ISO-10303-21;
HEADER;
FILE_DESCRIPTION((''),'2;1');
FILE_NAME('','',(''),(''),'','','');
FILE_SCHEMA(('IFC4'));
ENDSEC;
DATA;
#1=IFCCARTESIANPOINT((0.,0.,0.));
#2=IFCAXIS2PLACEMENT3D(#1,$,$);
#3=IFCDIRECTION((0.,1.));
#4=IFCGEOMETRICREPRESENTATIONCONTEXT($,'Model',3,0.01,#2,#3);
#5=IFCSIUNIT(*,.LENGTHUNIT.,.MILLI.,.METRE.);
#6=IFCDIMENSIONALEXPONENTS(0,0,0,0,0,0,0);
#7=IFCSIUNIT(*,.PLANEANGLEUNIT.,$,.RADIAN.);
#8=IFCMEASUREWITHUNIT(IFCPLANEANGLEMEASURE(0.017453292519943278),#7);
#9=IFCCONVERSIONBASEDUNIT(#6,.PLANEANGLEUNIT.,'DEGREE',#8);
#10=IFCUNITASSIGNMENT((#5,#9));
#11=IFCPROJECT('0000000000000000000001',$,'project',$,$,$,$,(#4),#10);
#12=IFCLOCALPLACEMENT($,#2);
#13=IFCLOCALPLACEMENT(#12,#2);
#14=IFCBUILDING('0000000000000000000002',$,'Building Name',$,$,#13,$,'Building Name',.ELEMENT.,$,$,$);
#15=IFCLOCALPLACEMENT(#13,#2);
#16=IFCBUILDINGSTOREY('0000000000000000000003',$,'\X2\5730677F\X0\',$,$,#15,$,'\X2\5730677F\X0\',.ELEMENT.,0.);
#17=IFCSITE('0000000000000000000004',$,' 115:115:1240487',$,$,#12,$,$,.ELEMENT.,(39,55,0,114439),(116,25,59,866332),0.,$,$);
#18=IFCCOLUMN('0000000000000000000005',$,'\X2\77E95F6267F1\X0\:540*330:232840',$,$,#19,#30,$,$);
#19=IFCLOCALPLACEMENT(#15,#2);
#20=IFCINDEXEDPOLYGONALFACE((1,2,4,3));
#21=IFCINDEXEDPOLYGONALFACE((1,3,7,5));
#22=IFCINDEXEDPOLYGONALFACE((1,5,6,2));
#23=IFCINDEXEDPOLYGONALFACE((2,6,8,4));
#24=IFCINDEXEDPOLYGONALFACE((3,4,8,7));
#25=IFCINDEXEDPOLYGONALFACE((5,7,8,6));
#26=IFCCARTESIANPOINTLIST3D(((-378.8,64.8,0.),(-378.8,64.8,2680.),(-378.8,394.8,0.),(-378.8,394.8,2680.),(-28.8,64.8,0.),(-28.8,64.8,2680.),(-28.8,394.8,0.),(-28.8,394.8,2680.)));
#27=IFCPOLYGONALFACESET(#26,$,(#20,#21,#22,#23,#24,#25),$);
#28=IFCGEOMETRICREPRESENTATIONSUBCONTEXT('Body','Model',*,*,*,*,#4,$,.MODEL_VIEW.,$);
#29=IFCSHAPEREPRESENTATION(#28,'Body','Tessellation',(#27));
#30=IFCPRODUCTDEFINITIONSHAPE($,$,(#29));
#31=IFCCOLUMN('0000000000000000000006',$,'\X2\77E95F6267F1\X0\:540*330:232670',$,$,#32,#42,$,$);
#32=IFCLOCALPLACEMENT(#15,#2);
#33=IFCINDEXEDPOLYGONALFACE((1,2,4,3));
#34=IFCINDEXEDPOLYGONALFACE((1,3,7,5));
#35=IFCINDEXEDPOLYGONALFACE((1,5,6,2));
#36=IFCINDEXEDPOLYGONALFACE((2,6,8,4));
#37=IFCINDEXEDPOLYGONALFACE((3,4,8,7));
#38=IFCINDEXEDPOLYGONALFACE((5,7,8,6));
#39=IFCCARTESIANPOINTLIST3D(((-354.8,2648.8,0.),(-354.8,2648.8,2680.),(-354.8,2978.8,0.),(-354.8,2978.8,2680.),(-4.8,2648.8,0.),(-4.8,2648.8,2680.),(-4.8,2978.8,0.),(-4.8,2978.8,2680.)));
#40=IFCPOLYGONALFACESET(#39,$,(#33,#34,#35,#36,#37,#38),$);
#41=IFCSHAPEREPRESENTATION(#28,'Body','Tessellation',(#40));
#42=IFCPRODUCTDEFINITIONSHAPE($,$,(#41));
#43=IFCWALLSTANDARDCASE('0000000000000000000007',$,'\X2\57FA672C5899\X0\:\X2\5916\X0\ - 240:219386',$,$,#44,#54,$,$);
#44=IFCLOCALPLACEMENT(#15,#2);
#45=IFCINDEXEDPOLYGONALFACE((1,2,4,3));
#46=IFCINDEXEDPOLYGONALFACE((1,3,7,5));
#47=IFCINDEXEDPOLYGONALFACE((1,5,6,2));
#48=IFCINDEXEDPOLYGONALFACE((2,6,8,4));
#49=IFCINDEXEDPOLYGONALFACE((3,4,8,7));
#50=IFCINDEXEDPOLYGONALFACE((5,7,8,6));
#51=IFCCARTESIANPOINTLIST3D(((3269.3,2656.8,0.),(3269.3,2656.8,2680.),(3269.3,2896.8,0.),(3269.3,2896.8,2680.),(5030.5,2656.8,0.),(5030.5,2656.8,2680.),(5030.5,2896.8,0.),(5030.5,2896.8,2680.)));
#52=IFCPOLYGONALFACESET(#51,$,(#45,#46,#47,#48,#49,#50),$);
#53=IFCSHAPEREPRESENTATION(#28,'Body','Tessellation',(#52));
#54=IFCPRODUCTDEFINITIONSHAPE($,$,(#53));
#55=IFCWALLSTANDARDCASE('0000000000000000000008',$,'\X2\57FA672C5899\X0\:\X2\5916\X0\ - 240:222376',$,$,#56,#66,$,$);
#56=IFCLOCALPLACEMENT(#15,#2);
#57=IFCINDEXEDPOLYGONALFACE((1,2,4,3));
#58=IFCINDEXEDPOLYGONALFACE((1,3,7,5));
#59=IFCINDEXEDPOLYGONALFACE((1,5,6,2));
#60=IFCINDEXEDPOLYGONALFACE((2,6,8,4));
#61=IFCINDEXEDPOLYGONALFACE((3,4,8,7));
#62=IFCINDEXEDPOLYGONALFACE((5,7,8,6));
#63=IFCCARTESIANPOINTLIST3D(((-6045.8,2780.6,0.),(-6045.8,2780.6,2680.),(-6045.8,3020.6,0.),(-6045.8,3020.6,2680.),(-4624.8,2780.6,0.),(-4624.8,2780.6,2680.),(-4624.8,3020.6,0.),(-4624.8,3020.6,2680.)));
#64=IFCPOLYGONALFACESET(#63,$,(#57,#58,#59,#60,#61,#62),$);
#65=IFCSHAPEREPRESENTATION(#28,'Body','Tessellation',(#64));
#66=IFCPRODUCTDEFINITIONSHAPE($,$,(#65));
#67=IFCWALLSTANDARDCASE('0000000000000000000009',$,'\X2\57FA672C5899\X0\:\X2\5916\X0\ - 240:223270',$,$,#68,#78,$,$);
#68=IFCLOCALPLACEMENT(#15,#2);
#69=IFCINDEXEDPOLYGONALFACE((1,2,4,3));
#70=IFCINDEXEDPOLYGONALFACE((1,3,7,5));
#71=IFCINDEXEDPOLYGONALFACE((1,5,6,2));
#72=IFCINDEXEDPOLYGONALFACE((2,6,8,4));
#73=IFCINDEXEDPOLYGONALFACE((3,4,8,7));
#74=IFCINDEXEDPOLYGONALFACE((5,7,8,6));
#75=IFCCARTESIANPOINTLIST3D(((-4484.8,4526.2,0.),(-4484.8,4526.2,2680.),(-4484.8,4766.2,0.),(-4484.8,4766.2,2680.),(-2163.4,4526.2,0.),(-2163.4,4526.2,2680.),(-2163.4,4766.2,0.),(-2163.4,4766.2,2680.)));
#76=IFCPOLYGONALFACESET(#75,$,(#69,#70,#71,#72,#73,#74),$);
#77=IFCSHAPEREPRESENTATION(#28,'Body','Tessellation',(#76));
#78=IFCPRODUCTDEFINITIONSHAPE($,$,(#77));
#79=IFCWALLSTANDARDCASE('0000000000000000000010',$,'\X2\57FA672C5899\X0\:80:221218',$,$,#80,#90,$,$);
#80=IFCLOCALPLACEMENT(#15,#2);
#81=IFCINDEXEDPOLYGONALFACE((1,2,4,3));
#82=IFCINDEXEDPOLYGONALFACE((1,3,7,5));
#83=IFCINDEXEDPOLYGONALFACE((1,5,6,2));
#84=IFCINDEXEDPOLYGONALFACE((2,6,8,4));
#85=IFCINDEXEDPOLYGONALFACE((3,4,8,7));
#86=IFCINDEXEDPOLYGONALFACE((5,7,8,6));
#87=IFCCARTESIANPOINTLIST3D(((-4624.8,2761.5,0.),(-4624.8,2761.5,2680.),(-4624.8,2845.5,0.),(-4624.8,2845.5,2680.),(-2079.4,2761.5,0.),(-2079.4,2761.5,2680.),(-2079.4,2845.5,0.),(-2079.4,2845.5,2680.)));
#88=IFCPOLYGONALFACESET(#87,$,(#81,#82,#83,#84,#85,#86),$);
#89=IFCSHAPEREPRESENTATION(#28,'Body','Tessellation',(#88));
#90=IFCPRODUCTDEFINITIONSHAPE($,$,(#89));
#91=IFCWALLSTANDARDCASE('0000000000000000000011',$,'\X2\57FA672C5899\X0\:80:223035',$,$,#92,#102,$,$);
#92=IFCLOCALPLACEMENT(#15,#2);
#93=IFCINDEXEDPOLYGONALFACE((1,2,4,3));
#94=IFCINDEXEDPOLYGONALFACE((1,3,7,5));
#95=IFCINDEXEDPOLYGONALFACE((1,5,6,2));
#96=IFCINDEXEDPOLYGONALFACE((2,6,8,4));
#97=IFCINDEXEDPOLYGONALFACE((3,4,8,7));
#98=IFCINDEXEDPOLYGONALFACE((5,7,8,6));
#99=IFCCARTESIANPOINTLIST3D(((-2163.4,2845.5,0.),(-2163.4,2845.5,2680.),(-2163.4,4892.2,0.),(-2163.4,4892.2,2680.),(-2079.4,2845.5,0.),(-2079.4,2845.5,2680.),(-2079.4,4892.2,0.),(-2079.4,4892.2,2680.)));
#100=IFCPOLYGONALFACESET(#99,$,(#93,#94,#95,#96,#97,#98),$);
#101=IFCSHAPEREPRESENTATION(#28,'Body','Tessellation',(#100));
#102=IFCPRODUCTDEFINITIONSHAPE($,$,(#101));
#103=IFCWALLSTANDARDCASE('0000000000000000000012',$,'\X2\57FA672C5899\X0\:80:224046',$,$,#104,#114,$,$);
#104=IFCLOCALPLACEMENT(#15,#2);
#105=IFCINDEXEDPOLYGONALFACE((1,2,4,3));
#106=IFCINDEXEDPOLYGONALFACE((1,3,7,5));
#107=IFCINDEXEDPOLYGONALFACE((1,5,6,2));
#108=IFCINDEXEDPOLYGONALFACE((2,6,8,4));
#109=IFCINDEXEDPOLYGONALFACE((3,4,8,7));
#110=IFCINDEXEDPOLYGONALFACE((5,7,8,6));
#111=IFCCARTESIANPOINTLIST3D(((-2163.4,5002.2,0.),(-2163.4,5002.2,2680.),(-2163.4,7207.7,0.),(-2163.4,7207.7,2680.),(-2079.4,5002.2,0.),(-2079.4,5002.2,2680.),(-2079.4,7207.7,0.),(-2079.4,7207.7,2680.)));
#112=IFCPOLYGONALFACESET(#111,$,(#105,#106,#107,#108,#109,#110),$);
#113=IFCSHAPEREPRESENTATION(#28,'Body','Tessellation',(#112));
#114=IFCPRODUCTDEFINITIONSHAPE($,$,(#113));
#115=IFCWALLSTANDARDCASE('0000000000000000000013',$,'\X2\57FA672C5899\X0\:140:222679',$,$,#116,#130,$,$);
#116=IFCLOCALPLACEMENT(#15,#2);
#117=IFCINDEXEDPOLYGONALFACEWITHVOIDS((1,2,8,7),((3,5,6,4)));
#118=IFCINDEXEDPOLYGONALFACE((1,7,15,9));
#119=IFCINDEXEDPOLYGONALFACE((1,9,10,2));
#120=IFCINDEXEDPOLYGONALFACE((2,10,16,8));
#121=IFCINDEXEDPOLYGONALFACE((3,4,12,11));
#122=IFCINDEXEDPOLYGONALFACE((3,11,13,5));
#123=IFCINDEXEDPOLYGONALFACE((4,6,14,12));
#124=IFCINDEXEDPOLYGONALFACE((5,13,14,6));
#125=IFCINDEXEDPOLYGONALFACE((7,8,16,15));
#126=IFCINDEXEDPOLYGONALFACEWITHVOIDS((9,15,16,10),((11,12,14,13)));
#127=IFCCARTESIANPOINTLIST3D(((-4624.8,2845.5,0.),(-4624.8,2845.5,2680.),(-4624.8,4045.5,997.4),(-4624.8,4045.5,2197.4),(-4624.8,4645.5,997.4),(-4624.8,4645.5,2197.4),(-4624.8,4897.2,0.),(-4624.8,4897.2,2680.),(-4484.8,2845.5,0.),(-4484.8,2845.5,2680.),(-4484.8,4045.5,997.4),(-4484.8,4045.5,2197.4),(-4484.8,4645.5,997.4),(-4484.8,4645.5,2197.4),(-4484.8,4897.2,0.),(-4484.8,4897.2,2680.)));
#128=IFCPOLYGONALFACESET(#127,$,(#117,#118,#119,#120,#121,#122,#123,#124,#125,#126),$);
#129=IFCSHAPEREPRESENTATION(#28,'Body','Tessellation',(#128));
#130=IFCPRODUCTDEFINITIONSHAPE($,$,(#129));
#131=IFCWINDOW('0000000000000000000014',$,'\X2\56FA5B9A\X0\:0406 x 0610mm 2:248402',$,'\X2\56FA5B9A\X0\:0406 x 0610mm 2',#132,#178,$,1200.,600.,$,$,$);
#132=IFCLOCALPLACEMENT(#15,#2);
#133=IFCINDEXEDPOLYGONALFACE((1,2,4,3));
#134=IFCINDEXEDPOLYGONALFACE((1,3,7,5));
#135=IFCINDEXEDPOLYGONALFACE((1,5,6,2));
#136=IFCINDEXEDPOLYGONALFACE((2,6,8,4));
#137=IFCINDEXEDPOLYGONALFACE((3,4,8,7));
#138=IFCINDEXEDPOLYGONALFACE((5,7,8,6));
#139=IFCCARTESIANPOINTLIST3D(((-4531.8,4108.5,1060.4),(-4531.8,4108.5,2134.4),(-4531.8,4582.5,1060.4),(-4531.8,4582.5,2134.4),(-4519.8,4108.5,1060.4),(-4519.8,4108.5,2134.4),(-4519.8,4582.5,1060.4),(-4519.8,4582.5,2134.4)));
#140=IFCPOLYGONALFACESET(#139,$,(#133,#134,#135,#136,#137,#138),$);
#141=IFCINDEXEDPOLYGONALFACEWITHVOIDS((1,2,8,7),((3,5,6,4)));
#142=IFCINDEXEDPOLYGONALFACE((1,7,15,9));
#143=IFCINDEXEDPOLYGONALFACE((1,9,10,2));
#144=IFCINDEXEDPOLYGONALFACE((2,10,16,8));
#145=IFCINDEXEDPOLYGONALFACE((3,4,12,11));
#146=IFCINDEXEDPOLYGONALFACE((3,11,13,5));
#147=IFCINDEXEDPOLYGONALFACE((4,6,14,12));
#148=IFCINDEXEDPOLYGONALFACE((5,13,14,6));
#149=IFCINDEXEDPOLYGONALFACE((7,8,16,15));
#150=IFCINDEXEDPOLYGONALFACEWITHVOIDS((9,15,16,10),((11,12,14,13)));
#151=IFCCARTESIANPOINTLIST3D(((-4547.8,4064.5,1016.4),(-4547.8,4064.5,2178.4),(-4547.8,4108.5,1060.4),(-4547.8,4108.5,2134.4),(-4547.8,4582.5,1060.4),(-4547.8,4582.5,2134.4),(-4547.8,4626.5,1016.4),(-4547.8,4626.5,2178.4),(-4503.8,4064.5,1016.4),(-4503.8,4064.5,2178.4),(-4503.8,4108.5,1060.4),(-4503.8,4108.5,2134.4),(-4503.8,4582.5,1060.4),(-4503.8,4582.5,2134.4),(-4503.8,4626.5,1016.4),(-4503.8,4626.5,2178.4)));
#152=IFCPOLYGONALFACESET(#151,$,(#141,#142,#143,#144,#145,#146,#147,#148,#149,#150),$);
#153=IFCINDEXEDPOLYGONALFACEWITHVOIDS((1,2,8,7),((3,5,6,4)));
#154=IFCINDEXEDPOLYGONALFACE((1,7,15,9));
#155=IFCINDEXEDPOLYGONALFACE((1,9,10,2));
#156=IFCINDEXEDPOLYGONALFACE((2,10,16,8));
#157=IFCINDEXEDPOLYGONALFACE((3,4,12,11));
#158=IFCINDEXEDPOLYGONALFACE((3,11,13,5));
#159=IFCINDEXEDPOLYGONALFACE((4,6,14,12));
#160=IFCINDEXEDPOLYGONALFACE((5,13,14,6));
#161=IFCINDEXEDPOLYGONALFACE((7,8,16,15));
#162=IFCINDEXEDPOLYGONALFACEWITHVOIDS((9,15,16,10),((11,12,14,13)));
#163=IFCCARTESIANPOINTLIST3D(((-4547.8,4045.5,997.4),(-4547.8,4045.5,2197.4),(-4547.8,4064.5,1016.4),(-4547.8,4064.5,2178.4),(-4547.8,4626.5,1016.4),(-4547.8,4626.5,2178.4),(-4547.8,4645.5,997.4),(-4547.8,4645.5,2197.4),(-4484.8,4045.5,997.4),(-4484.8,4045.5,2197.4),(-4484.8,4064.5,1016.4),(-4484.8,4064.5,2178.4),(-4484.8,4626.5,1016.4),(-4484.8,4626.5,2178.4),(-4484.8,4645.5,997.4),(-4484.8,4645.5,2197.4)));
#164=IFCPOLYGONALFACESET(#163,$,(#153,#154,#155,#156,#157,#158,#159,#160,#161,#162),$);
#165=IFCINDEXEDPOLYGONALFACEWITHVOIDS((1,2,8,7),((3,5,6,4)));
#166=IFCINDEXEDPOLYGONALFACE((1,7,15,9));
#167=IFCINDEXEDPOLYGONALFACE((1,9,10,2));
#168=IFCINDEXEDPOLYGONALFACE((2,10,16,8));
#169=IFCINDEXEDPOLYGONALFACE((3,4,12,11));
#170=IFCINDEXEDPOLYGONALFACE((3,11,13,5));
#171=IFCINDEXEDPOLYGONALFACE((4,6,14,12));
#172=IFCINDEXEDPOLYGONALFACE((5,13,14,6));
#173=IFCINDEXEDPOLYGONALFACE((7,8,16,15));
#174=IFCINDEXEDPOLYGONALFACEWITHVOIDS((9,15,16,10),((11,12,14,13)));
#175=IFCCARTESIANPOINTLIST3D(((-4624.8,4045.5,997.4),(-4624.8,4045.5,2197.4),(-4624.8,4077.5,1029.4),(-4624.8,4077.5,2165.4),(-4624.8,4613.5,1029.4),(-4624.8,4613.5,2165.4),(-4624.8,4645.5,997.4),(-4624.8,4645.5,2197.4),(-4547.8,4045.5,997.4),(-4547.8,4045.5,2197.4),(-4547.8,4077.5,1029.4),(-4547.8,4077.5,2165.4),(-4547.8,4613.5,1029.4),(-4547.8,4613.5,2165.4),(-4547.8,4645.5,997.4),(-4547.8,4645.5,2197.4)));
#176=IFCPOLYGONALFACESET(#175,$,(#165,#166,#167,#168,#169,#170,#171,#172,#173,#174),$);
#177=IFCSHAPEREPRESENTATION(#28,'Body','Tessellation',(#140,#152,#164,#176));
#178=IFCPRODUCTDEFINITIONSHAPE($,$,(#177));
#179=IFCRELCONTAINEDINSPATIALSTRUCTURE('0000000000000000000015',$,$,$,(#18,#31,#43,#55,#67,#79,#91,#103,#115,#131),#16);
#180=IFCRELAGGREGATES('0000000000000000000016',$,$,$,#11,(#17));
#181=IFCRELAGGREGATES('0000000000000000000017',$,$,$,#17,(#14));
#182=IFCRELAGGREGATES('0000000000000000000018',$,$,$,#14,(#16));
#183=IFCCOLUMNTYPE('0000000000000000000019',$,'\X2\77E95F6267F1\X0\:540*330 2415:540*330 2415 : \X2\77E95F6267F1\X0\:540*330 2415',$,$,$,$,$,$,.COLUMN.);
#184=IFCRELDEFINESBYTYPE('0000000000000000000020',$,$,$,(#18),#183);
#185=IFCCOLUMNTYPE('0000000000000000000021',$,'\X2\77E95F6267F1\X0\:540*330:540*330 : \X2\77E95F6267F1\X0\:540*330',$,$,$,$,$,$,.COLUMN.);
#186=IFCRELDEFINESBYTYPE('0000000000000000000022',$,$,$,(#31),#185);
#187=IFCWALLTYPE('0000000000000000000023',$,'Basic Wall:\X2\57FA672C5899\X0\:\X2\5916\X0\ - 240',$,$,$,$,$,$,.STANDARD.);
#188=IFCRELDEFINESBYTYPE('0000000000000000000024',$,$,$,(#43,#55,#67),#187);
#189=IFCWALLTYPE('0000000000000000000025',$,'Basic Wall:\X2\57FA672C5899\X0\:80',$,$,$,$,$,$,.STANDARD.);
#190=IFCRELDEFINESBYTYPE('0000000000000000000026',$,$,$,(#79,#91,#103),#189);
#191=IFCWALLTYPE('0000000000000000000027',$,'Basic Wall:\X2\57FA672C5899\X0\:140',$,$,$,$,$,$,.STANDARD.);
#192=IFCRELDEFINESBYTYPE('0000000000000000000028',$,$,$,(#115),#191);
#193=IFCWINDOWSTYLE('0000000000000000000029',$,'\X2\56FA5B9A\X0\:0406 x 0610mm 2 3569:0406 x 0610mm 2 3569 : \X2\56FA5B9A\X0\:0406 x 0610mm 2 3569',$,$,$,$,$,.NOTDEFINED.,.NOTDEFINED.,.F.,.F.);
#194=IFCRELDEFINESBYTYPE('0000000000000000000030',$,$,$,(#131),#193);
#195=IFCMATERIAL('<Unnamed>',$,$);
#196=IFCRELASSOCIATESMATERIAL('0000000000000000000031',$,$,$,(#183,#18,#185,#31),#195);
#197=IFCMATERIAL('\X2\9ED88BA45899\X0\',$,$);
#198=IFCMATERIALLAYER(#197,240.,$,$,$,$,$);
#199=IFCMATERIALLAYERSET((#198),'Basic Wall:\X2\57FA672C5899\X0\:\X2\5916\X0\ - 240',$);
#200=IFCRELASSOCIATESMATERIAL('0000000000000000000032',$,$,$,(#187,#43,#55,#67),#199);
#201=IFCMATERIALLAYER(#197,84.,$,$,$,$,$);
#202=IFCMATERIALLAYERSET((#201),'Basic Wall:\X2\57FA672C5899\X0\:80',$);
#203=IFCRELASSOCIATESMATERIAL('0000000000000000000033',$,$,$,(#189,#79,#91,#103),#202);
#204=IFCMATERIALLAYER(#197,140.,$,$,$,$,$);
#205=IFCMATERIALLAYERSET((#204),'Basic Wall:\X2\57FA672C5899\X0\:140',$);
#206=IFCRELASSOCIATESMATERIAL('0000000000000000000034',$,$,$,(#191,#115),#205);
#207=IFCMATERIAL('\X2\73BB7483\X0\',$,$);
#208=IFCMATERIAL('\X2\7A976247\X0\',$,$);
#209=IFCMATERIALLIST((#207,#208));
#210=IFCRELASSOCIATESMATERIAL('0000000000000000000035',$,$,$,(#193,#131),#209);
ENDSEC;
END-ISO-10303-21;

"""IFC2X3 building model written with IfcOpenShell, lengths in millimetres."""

from ifc_helpers import new_model, entity, si_unit, converted_unit, direction, frame, frame_2d, origin, origin_2d_with_axis, place, context, subcontext, project, spatial, polyline, rectangle, outline, extrude, source, transform, mapped, material, material_list, layer, layer_set, layer_usage, type_object, type_shapes, element, fill, save


model = new_model("IFC2X3")

# Units and contexts
model_context = context("Model", 3, precision=0.01, world=origin(), true_north=direction((0.0, 1.0)))
body_context = subcontext(model_context, "Body", "Model", "MODEL_VIEW")
ifc_project = project(units=[si_unit("LENGTHUNIT", "METRE", prefix="MILLI"), converted_unit("PLANEANGLEUNIT", "DEGREE", entity("IfcPlaneAngleMeasure", 0.017453292519943278), si_unit("PLANEANGLEUNIT", "RADIAN"), dimensions=[0, 0, 0, 0, 0, 0, 0])], contexts=[model_context])

# Site, building, storey
site_placement = place(None, origin())
site = spatial("IfcSite", under=ifc_project, at=site_placement, Name=" 115:115:1240487", CompositionType="ELEMENT", RefLatitude=(39, 55, 0, 114439), RefLongitude=(116, 25, 59, 866332), RefElevation=0.0)
building_placement = place(site_placement, origin())
building = spatial("IfcBuilding", under=site, at=building_placement, Name="Building Name", LongName="Building Name", CompositionType="ELEMENT")
storey_placement = place(building_placement, origin())
storey = spatial("IfcBuildingStorey", under=building, at=storey_placement, Name="地板", LongName="地板", CompositionType="ELEMENT", Elevation=0.0)

# Columns
ifc_material_1 = material(Name="<Unnamed>")
column_type_1 = type_object("IfcColumnType", Name="矩形柱:540*330 2415:540*330 2415 : 矩形柱:540*330 2415", PredefinedType="COLUMN", material=ifc_material_1)
shared_shape_1 = source(origin(), body_context, "Body", "SweptSolid", [
    extrude(rectangle(XDim=350.0, YDim=330.0, at=origin_2d_with_axis()), frame((-203.8, 229.8, 0.0)), (0.0, 0.0, 1.0), 2680.0),
])
type_shapes(column_type_1, [shared_shape_1])
column_1_placement = place(storey_placement, origin())
element("IfcColumn", 1, at=column_1_placement, inside=storey, type_object=column_type_1, material=ifc_material_1, Name="矩形柱:540*330:232840", context=body_context, shape_type="MappedRepresentation", body=[
    mapped(shared_shape_1, transform((0.0, 0.0, 0.0), scale=1.0)),
])
column_type_2 = type_object("IfcColumnType", Name="矩形柱:540*330:540*330 : 矩形柱:540*330", PredefinedType="COLUMN", material=ifc_material_1)
shared_shape_2 = source(origin(), body_context, "Body", "SweptSolid", [
    extrude(rectangle(XDim=350.0, YDim=330.0, at=frame_2d((0.0, 0.0), x_axis=(1.0, 0.0))), frame((-179.8, 2813.8, 0.0)), (0.0, 0.0, 1.0), 2680.0),
])
type_shapes(column_type_2, [shared_shape_2])
column_2_placement = place(storey_placement, origin())
element("IfcColumn", 2, at=column_2_placement, inside=storey, type_object=column_type_2, material=ifc_material_1, Name="矩形柱:540*330:232670", context=body_context, shape_type="MappedRepresentation", body=[
    mapped(shared_shape_2, transform((0.0, 0.0, 0.0), scale=1.0)),
])
ifc_material_2 = material(Name="默认墙")

# Walls
ifc_layer_1 = layer(ifc_material_2, 240.0)
ifc_layer_set_1 = layer_set([ifc_layer_1], Name="Basic Wall:基本墙:外 - 240")
ifc_layer_usage_1 = layer_usage(ifc_layer_set_1, "AXIS2", "NEGATIVE", 120.0)
wall_type_1 = type_object("IfcWallType", Name="Basic Wall:基本墙:外 - 240", PredefinedType="STANDARD", material=ifc_layer_set_1)
wall_1_placement = place(storey_placement, frame((5030.5, 2776.8, 0.0), z_axis=(0.0, 0.0, 1.0), x_axis=(-1.0, 0.0, 0.0)))
element("IfcWallStandardCase", 3, at=wall_1_placement, inside=storey, type_object=wall_type_1, material=ifc_layer_usage_1, Name="基本墙:外 - 240:219386", context=body_context, shape_type="SweptSolid", body=[
    extrude(rectangle(XDim=1761.2, YDim=240.0, at=frame_2d((880.6, 0.0), x_axis=(-1.0, 0.0))), origin(), (0.0, 0.0, 1.0), 2680.0),
])
ifc_layer_usage_2 = layer_usage(ifc_layer_set_1, "AXIS2", "NEGATIVE", 120.0)
wall_2_placement = place(storey_placement, frame((-6045.8, 2900.6, 0.0)))
element("IfcWallStandardCase", 4, at=wall_2_placement, inside=storey, type_object=wall_type_1, material=ifc_layer_usage_2, Name="基本墙:外 - 240:222376", context=body_context, shape_type="SweptSolid", body=[
    extrude(rectangle(XDim=1421.1, YDim=240.0, at=frame_2d((710.5, 0.0), x_axis=(-1.0, 0.0))), origin(), (0.0, 0.0, 1.0), 2680.0),
])
ifc_layer_usage_3 = layer_usage(ifc_layer_set_1, "AXIS2", "NEGATIVE", 120.0)
wall_3_placement = place(storey_placement, frame((-4484.8, 4646.2, 0.0)))
element("IfcWallStandardCase", 5, at=wall_3_placement, inside=storey, type_object=wall_type_1, material=ifc_layer_usage_3, Name="基本墙:外 - 240:223270", context=body_context, shape_type="SweptSolid", body=[
    extrude(rectangle(XDim=2321.3, YDim=240.0, at=frame_2d((1160.7, 0.0), x_axis=(-1.0, 0.0))), origin(), (0.0, 0.0, 1.0), 2680.0),
])
ifc_layer_2 = layer(ifc_material_2, 84.0)
ifc_layer_set_2 = layer_set([ifc_layer_2], Name="Basic Wall:基本墙:80")
ifc_layer_usage_4 = layer_usage(ifc_layer_set_2, "AXIS2", "NEGATIVE", 42.0)
wall_type_2 = type_object("IfcWallType", Name="Basic Wall:基本墙:80", PredefinedType="STANDARD", material=ifc_layer_set_2)
wall_4_placement = place(storey_placement, frame((-4624.8, 2803.5, 0.0)))
element("IfcWallStandardCase", 6, at=wall_4_placement, inside=storey, type_object=wall_type_2, material=ifc_layer_usage_4, Name="基本墙:80:221218", context=body_context, shape_type="SweptSolid", body=[
    extrude(rectangle(XDim=2545.3, YDim=84.0, at=frame_2d((1272.7, 0.0), x_axis=(-1.0, 0.0))), origin(), (0.0, 0.0, 1.0), 2680.0),
])
ifc_layer_usage_5 = layer_usage(ifc_layer_set_2, "AXIS2", "NEGATIVE", 42.0)
wall_5_placement = place(storey_placement, frame((-2121.4, 2845.5, 0.0), z_axis=(0.0, 0.0, 1.0), x_axis=(0.0, 1.0, 0.0)))
element("IfcWallStandardCase", 7, at=wall_5_placement, inside=storey, type_object=wall_type_2, material=ifc_layer_usage_5, Name="基本墙:80:223035", context=body_context, shape_type="SweptSolid", body=[
    extrude(rectangle(XDim=2046.6, YDim=84.0, at=frame_2d((1023.3, 0.0), x_axis=(-1.0, 0.0))), origin(), (0.0, 0.0, 1.0), 2680.0),
])
ifc_layer_usage_6 = layer_usage(ifc_layer_set_2, "AXIS2", "NEGATIVE", 42.0)
wall_6_placement = place(storey_placement, frame((-2121.4, 5002.2, 0.0), z_axis=(0.0, 0.0, 1.0), x_axis=(0.0, 1.0, 0.0)))
element("IfcWallStandardCase", 8, at=wall_6_placement, inside=storey, type_object=wall_type_2, material=ifc_layer_usage_6, Name="基本墙:80:224046", context=body_context, shape_type="SweptSolid", body=[
    extrude(rectangle(XDim=2205.5, YDim=84.0, at=frame_2d((1102.8, 0.0), x_axis=(-1.0, 0.0))), origin(), (0.0, 0.0, 1.0), 2680.0),
])

# Wall, opening, window
ifc_layer_3 = layer(ifc_material_2, 140.0)
ifc_layer_set_3 = layer_set([ifc_layer_3], Name="Basic Wall:基本墙:140")
ifc_layer_usage_7 = layer_usage(ifc_layer_set_3, "AXIS2", "NEGATIVE", 70.0)
wall_type_3 = type_object("IfcWallType", Name="Basic Wall:基本墙:140", PredefinedType="STANDARD", material=ifc_layer_set_3)
wall_7_placement = place(storey_placement, frame((-4554.8, 2845.5, 0.0), z_axis=(0.0, 0.0, 1.0), x_axis=(0.0, 1.0, 0.0)))
wall_7 = element("IfcWallStandardCase", 9, at=wall_7_placement, inside=storey, type_object=wall_type_3, material=ifc_layer_usage_7, Name="基本墙:140:222679", context=body_context, shape_type="SweptSolid", body=[
    extrude(rectangle(XDim=2051.7, YDim=140.0, at=frame_2d((1025.8, 0.0), x_axis=(-1.0, 0.0))), origin(), (0.0, 0.0, 1.0), 2680.0),
])
opening_placement = place(wall_7_placement, frame((-2845.5, -4554.8, 0.0), z_axis=(0.0, 0.0, 1.0), x_axis=(0.0, -1.0, 0.0)))
opening = element("IfcOpeningElement", 10, at=opening_placement, cuts=wall_7, ObjectType="Opening", context=body_context, shape_type="SweptSolid", body=[
    extrude(rectangle(XDim=1200.0, YDim=600.0, at=origin_2d_with_axis()), frame((-4483.4, 4345.5, 1597.4), z_axis=(-1.0, 0.0, 0.0), x_axis=(0.0, 0.0, -1.0)), (0.0, 0.0, 1.0), 142.8),
])
ifc_material_3 = material(Name="玻璃")
ifc_material_4 = material(Name="窗扇")
ifc_material_list = material_list([ifc_material_3, ifc_material_4])
window_style = type_object("IfcWindowStyle", Name="固定:0406 x 0610mm 2 3569:0406 x 0610mm 2 3569 : 固定:0406 x 0610mm 2 3569", ConstructionType="NOTDEFINED", OperationType="NOTDEFINED", ParameterTakesPrecedence=False, Sizeable=False, material=ifc_material_list)
shared_shape_3 = source(origin(), body_context, "Body", "SweptSolid", [
    extrude(rectangle(XDim=474.0, YDim=12.0, at=origin_2d_with_axis()), frame((300.0, 100.4, 63.0)), (0.0, 0.0, 1.0), 1074.0),
    extrude(outline(polyline([(-581.0, -281.0), (581.0, -281.0), (581.0, 281.0), (-581.0, 281.0), (-581.0, -281.0)]), holes=[polyline([(537.0, 237.0), (537.0, -237.0), (-537.0, -237.0), (-537.0, 237.0), (537.0, 237.0)])]), frame((300.0, 78.4, 600.0), z_axis=(0.0, 1.0, 0.0), x_axis=(0.0, 0.0, -1.0)), (0.0, 0.0, 1.0), 44.0),
    extrude(outline(polyline([(-600.0, -300.0), (600.0, -300.0), (600.0, 300.0), (-600.0, 300.0), (-600.0, -300.0)]), holes=[polyline([(581.0, 281.0), (581.0, -281.0), (-581.0, -281.0), (-581.0, 281.0), (581.0, 281.0)])]), frame((300.0, 78.4, 600.0), z_axis=(0.0, 1.0, 0.0), x_axis=(0.0, 0.0, -1.0)), (0.0, 0.0, 1.0), 63.0),
    extrude(outline(polyline([(-600.0, -300.0), (600.0, -300.0), (600.0, 300.0), (-600.0, 300.0), (-600.0, -300.0)]), holes=[polyline([(568.0, 268.0), (568.0, -268.0), (-568.0, -268.0), (-568.0, 268.0), (568.0, 268.0)])]), frame((300.0, 1.4, 600.0), z_axis=(0.0, 1.0, 0.0), x_axis=(0.0, 0.0, -1.0)), (0.0, 0.0, 1.0), 77.0),
])
type_shapes(window_style, [shared_shape_3])
window_placement = place(opening_placement, frame((-4626.2, 4645.5, 997.4), z_axis=(0.0, 0.0, 1.0), x_axis=(0.0, -1.0, 0.0)))
window = element("IfcWindow", 11, at=window_placement, inside=storey, type_object=window_style, material=ifc_material_list, Name="固定:0406 x 0610mm 2:248402", ObjectType="固定:0406 x 0610mm 2", OverallHeight=1200.0, OverallWidth=600.0, context=body_context, shape_type="MappedRepresentation", body=[
    mapped(shared_shape_3, transform((0.0, 0.0, 0.0), scale=1.0)),
])
fill(opening, window)

save(model, "model.ifc")
